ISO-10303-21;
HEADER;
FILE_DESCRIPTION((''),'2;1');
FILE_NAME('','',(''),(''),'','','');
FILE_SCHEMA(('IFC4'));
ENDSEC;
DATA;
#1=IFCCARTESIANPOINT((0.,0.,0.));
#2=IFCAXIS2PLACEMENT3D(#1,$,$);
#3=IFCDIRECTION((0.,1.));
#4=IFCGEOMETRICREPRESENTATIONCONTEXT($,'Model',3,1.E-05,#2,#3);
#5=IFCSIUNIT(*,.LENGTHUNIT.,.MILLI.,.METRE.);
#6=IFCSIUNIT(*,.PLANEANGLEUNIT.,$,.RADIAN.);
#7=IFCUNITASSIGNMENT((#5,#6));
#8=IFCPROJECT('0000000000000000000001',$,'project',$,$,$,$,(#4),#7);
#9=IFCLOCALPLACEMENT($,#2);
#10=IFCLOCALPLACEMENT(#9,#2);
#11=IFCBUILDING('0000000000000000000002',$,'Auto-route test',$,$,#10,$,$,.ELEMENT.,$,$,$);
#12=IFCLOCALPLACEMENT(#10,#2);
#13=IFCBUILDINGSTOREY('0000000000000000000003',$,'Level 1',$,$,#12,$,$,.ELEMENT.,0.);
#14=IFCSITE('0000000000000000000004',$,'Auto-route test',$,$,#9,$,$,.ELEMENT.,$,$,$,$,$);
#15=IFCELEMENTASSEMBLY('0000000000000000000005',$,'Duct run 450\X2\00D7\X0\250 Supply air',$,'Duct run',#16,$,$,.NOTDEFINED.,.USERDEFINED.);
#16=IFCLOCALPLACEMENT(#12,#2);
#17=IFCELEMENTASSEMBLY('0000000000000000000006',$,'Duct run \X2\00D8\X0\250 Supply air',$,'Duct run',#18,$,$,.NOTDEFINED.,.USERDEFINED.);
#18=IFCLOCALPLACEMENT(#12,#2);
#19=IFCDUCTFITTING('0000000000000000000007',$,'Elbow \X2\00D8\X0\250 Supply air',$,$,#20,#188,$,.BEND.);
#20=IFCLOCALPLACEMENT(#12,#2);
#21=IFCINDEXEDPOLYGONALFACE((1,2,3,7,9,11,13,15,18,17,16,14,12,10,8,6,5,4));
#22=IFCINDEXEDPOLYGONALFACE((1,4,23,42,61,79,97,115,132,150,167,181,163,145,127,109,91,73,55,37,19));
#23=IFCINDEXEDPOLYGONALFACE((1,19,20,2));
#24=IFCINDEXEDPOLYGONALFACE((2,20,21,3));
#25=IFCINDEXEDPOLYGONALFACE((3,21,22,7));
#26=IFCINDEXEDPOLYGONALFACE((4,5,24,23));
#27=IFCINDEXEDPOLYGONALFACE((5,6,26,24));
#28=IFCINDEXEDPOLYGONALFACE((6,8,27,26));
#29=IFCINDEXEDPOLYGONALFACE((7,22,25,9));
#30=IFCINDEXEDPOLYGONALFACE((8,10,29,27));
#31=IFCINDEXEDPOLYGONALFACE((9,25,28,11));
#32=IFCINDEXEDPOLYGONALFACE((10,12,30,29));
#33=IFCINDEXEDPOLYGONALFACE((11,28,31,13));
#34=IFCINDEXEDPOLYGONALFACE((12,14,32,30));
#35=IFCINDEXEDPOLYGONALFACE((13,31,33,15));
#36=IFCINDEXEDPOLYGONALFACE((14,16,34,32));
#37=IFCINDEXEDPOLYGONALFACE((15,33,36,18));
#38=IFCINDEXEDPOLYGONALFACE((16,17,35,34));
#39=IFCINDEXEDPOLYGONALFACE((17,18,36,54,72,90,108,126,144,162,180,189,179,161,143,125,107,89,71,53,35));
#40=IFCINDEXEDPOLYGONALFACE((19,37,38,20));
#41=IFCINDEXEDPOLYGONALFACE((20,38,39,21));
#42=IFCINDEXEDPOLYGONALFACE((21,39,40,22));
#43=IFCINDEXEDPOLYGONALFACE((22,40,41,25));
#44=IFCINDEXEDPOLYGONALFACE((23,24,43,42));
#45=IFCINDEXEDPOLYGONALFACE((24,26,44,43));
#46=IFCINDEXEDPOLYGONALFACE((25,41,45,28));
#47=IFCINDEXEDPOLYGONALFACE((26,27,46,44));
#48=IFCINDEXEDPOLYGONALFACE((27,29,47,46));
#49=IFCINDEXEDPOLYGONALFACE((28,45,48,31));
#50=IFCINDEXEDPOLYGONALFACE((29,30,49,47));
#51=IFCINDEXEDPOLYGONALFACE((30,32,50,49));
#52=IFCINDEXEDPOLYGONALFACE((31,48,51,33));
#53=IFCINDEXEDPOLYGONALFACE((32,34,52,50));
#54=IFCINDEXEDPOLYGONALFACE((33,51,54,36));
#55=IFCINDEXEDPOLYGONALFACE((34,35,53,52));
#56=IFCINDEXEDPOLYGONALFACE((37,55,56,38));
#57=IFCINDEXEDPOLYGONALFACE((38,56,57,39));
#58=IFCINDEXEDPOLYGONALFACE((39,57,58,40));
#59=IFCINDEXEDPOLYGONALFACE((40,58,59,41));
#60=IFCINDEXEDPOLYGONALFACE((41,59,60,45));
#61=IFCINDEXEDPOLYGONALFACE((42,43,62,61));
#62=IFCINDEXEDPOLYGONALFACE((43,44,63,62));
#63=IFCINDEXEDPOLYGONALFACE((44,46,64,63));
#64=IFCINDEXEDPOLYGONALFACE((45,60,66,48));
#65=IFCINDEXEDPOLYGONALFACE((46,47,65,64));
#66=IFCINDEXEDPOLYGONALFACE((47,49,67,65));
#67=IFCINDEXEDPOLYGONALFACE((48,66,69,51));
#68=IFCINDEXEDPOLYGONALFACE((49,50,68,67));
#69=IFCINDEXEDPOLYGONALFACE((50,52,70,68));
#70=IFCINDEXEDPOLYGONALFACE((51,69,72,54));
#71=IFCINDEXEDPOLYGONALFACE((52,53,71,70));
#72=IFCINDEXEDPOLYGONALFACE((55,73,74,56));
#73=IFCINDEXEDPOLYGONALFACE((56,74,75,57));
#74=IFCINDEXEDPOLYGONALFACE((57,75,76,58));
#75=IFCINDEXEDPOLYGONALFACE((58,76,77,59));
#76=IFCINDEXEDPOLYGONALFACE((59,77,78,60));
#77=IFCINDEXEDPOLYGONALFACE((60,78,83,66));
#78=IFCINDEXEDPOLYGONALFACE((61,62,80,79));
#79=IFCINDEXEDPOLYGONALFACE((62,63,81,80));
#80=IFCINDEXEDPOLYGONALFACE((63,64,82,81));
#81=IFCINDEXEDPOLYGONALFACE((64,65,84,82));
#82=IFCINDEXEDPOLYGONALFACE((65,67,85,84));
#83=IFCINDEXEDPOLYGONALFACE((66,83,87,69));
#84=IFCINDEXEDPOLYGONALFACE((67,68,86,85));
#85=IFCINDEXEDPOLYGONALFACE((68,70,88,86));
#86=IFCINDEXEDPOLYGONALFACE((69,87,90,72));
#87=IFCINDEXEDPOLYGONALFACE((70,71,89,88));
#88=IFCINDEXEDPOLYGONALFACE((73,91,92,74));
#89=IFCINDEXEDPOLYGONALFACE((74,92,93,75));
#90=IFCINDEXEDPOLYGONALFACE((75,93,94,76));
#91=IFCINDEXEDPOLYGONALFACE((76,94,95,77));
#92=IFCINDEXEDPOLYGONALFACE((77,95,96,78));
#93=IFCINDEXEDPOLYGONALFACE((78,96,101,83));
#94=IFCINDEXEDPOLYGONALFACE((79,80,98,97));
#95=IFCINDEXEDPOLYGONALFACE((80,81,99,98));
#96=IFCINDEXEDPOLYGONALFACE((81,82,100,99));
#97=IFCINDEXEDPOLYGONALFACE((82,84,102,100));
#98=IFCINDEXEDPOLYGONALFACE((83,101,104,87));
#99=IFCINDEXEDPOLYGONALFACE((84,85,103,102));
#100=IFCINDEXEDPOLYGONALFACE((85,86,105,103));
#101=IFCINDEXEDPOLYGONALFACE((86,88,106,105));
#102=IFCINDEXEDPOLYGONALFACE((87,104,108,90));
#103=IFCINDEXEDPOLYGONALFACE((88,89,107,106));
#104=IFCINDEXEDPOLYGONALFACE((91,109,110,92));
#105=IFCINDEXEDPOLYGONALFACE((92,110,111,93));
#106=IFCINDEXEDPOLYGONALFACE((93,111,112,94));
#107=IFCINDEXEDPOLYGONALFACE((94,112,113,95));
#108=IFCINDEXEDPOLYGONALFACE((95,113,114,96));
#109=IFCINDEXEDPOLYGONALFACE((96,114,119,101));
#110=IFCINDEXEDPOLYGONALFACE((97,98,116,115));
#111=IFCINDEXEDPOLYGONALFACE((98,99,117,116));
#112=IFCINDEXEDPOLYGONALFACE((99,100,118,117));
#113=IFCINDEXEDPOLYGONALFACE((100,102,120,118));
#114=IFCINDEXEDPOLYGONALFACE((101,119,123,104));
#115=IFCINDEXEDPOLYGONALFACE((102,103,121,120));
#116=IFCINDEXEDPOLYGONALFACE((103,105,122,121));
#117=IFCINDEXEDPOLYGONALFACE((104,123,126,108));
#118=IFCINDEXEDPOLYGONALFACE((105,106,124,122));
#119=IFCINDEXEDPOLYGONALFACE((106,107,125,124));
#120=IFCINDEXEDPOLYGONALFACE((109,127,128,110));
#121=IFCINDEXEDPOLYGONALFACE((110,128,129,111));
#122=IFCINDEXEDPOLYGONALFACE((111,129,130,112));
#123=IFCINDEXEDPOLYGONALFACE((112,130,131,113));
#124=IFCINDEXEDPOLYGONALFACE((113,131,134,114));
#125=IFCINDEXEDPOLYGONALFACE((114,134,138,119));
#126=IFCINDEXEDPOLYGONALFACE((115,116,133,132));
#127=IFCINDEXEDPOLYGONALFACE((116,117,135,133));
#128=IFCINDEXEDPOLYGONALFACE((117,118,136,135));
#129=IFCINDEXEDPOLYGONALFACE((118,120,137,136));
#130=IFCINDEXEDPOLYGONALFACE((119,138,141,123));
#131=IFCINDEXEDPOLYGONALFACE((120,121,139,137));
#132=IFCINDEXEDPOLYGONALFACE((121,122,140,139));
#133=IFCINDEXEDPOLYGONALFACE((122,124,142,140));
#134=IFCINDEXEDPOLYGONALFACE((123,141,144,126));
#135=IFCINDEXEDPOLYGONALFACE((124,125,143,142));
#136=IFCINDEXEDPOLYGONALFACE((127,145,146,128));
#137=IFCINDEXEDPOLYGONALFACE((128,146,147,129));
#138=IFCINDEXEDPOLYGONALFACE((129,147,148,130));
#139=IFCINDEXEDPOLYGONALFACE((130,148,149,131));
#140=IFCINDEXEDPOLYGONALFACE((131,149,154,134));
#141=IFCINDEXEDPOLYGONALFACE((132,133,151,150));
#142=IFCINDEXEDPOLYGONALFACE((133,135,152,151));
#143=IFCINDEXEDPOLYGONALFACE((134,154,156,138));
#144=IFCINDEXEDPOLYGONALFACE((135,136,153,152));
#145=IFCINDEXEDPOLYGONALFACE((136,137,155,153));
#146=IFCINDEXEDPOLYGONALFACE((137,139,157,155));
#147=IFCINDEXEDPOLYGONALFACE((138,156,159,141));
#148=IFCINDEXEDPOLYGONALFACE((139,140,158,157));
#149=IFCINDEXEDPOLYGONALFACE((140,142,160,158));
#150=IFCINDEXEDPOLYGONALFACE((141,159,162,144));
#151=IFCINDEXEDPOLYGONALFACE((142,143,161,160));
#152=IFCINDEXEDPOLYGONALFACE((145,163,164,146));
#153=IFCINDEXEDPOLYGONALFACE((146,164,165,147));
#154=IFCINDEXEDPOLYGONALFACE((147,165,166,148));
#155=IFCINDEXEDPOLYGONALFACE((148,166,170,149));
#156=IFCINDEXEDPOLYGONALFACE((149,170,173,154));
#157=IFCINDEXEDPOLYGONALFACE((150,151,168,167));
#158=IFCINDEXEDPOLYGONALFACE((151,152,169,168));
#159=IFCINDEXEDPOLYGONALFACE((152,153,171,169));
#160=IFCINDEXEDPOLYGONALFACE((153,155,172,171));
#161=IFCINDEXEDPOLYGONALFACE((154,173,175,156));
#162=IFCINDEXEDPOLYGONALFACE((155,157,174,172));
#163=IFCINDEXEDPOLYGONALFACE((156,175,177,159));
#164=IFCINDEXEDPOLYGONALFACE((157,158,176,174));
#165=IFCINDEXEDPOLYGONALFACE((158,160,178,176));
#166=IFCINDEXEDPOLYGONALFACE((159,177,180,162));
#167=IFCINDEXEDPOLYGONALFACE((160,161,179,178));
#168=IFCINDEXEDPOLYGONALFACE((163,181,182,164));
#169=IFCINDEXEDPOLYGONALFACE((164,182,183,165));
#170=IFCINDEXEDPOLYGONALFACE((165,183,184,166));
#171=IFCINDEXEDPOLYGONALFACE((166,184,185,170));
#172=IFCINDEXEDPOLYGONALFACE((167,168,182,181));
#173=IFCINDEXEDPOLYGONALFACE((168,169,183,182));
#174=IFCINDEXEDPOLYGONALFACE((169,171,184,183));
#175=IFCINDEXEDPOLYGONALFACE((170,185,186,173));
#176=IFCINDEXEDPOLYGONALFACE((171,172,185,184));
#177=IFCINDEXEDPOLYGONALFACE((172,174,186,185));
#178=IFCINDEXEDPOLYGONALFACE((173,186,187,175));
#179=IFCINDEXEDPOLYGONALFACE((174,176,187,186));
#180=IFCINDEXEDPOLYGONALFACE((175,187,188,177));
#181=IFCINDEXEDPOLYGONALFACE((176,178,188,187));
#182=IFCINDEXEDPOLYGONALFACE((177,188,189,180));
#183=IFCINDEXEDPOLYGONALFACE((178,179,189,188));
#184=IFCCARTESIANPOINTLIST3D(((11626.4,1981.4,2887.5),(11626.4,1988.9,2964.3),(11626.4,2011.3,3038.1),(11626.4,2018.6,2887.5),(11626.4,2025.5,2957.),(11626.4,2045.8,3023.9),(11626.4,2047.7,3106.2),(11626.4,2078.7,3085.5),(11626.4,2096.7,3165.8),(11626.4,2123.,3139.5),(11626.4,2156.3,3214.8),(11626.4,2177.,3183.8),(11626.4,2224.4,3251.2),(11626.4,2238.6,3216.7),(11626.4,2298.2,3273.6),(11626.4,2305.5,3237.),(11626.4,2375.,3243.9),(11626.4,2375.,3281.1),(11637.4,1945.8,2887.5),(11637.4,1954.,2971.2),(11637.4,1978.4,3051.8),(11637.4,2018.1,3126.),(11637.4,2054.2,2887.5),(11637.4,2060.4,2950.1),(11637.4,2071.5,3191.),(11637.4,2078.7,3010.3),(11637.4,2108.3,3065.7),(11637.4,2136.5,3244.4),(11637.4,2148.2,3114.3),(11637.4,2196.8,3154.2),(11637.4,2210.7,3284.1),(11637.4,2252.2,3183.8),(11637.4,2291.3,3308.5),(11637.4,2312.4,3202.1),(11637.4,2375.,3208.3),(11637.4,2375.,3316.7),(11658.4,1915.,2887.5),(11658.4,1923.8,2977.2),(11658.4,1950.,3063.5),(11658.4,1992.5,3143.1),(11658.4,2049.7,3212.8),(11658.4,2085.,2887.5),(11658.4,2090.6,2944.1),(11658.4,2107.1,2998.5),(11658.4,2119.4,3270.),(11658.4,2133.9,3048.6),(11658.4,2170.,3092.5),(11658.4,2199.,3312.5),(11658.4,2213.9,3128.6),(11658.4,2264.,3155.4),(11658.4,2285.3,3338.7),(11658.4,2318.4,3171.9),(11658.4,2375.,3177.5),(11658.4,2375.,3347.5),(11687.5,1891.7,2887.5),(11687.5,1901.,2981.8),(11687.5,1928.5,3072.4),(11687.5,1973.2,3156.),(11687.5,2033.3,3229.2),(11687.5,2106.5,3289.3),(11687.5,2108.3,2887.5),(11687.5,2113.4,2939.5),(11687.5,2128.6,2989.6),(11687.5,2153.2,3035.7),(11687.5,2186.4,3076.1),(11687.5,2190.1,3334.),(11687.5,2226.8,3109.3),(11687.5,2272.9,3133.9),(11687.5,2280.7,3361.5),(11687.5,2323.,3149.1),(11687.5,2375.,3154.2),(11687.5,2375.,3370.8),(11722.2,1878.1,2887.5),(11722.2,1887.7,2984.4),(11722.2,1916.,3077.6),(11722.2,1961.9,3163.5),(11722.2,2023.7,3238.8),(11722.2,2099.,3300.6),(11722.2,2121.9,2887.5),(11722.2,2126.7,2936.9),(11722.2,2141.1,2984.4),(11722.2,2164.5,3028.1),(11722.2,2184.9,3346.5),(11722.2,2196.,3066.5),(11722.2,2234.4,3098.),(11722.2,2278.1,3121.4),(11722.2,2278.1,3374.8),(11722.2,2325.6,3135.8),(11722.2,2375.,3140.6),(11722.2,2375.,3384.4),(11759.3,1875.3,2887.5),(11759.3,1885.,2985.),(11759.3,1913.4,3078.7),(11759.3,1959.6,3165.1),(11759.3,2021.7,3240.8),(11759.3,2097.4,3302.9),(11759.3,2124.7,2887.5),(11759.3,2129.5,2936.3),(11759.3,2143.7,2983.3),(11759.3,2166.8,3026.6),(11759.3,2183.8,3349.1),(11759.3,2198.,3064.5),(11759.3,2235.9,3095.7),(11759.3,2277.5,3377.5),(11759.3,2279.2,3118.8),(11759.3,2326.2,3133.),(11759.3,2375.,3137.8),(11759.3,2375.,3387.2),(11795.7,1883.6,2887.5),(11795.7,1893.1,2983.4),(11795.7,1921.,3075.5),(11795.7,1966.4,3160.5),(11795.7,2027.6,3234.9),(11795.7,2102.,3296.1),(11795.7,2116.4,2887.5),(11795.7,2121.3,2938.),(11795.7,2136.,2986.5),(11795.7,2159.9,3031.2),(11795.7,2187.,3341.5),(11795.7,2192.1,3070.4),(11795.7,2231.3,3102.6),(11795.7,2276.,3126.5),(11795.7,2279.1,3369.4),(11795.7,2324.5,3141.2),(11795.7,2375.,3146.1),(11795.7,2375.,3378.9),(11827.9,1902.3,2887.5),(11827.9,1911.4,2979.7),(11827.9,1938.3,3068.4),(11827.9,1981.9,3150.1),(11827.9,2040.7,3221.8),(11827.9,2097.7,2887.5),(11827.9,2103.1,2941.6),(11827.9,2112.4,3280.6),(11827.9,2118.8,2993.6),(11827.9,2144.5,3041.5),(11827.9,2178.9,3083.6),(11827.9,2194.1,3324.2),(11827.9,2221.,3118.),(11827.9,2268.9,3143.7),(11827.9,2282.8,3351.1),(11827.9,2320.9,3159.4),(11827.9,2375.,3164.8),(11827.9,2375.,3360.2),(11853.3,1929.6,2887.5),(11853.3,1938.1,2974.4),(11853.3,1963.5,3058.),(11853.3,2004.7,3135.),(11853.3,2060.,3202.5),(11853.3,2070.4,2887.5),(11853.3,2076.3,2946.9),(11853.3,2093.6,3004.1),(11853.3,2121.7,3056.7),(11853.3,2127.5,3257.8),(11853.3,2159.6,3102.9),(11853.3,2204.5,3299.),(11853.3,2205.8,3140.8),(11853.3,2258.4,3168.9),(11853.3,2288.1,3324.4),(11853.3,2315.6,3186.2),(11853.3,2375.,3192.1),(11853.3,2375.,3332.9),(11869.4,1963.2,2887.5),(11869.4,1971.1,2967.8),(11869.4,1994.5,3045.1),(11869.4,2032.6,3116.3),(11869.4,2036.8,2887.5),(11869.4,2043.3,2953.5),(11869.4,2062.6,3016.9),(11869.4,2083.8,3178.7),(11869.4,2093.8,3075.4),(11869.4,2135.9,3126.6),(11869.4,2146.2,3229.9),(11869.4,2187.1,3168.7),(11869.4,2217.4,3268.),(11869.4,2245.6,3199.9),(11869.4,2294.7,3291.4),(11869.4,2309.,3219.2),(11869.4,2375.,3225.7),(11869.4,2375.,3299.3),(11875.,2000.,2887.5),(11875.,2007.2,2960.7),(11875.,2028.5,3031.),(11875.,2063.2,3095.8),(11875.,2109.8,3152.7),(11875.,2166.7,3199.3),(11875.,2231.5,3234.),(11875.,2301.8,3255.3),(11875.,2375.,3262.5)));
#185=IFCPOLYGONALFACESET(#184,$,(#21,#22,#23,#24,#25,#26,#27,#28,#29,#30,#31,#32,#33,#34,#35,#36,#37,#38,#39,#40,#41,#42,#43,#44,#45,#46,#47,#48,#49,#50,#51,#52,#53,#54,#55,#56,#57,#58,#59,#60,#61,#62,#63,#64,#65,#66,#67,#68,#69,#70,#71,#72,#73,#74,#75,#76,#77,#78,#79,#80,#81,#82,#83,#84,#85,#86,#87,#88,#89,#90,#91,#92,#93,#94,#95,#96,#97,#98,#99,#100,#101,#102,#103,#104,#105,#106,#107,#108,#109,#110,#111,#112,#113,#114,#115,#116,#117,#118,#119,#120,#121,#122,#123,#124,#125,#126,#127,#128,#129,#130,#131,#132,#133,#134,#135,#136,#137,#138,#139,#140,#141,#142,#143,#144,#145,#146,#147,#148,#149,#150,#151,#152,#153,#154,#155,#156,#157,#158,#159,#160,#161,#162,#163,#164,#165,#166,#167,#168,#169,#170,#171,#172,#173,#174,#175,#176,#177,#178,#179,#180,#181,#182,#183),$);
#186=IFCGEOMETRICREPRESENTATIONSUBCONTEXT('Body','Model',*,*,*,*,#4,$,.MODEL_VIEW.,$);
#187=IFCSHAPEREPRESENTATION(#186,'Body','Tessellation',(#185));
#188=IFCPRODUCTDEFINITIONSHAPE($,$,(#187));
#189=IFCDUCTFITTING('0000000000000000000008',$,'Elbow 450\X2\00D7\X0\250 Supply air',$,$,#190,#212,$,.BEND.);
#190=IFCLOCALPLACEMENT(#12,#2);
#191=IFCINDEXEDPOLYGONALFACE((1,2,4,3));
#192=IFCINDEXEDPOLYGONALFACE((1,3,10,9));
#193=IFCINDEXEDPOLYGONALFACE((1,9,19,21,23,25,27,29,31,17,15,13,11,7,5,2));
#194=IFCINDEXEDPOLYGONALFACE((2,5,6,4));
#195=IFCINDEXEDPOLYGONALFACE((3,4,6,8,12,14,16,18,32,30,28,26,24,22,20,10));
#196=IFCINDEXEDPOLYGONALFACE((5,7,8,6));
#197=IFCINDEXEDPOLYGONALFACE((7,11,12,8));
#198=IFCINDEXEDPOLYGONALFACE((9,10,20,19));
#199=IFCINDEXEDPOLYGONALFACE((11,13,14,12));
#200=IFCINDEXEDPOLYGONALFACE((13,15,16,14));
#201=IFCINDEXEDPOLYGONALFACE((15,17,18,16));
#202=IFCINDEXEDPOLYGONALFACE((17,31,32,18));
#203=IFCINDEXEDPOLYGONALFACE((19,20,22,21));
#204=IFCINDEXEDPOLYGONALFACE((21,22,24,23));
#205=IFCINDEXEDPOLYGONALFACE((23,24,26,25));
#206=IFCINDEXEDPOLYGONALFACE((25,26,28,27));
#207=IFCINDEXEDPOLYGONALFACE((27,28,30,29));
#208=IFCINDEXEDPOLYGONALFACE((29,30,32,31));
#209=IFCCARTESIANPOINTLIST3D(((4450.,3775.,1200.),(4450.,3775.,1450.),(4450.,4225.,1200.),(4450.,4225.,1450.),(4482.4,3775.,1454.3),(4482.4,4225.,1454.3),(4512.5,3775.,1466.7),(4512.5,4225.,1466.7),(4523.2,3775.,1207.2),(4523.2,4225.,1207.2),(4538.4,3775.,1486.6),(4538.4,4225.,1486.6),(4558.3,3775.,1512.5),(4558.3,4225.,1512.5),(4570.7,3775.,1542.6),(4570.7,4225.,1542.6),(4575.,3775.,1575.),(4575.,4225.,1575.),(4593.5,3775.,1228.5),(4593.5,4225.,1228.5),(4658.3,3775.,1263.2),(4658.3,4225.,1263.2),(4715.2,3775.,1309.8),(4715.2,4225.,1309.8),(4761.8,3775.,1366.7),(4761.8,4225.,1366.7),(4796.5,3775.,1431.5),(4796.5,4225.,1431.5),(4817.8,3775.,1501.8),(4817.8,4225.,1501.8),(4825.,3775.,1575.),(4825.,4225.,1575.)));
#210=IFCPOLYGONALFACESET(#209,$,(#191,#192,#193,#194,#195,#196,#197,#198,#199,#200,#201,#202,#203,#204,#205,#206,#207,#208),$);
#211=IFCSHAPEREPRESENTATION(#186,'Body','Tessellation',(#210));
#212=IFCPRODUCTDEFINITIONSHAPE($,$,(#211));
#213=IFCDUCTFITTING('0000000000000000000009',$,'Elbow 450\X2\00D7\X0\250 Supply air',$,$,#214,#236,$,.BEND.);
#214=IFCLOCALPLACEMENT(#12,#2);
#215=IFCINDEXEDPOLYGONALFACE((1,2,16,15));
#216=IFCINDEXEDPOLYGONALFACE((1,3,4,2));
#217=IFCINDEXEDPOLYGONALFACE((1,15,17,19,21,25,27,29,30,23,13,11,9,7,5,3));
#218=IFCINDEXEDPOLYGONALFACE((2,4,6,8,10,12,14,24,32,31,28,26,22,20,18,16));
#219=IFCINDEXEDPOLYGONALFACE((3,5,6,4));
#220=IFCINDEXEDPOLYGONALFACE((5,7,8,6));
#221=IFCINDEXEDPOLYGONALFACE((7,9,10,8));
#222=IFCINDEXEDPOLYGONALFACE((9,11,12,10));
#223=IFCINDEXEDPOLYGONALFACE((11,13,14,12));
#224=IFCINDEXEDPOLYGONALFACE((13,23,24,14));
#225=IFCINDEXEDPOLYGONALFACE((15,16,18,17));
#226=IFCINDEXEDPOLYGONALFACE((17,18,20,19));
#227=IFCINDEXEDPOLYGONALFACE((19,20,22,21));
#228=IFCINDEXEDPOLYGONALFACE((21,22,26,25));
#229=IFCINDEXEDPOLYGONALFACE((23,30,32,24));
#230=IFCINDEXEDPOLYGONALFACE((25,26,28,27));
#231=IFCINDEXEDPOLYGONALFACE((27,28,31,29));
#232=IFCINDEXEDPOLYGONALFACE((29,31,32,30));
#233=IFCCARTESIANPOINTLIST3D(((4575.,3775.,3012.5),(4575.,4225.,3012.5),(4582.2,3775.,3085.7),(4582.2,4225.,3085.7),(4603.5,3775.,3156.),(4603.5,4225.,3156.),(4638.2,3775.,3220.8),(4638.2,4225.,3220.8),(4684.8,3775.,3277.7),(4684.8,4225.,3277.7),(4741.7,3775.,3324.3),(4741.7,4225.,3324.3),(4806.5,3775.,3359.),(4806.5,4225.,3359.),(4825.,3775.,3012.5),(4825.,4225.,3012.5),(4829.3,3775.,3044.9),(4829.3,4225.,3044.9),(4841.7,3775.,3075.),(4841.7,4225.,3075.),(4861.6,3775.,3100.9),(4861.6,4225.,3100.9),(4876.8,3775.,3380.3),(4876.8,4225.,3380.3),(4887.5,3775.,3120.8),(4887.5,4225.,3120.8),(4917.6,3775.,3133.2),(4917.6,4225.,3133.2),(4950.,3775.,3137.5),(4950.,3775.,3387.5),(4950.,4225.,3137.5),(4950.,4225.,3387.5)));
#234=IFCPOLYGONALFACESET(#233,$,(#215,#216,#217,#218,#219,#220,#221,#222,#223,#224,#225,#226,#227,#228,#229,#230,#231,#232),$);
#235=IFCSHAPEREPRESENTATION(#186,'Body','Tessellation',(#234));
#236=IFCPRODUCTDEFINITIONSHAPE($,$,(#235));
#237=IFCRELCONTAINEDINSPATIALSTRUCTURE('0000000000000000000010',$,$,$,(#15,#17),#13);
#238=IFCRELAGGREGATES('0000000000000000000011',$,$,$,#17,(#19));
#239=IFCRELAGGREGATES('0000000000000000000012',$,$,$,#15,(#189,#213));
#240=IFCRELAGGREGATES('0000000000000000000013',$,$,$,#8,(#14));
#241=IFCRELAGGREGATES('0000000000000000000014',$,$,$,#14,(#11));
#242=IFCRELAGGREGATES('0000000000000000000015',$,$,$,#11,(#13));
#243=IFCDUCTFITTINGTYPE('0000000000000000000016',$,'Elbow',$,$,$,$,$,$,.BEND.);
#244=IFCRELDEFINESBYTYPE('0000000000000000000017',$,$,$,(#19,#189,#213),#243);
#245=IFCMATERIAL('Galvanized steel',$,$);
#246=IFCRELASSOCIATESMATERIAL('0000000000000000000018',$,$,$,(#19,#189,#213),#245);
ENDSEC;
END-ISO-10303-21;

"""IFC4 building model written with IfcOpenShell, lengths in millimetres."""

from ifc_helpers import new_model, entity, si_unit, direction, origin, origin_with_axes, place, context, subcontext, project, spatial, material, type_object, element, aggregate, save


model = new_model("IFC4")

# Units and contexts
model_context = context("Model", 3, precision=1e-05, world=origin(), true_north=direction((0.0, 1.0)))
body_context = subcontext(model_context, "Body", "Model", "MODEL_VIEW")
ifc_project = project(units=[si_unit("LENGTHUNIT", "METRE", prefix="MILLI"), si_unit("PLANEANGLEUNIT", "RADIAN")], contexts=[model_context])

# Site, building, storey
site_placement = place(None, origin())
site = spatial("IfcSite", under=ifc_project, at=site_placement, Name="Auto-route test", CompositionType="ELEMENT")
building_placement = place(site_placement, origin())
building = spatial("IfcBuilding", under=site, at=building_placement, Name="Auto-route test", CompositionType="ELEMENT")
storey_placement = place(building_placement, origin())
storey = spatial("IfcBuildingStorey", under=building, at=storey_placement, Name="Level 1", CompositionType="ELEMENT", Elevation=0.0)

# Element assembly
assembly_1_placement = place(storey_placement, origin_with_axes())
assembly_1 = element("IfcElementAssembly", 1, at=assembly_1_placement, inside=storey, Name="Duct run 450×250 Supply air", ObjectType="Duct run", AssemblyPlace="NOTDEFINED", PredefinedType="USERDEFINED")
ifc_material_1 = material(Name="Galvanized steel")

# Element assembly, duct fitting
assembly_2_placement = place(storey_placement, origin_with_axes())
assembly_2 = element("IfcElementAssembly", 2, at=assembly_2_placement, inside=storey, Name="Duct run Ø250 Supply air", ObjectType="Duct run", AssemblyPlace="NOTDEFINED", PredefinedType="USERDEFINED")
duct_fitting_type_1 = type_object("IfcDuctFittingType", Name="Elbow", PredefinedType="BEND")
duct_fitting_1_placement = place(storey_placement, origin_with_axes())
duct_fitting_1 = element("IfcDuctFitting", 3, at=duct_fitting_1_placement, type_object=duct_fitting_type_1, material=ifc_material_1, Name="Elbow Ø250 Supply air", PredefinedType="BEND", context=body_context, shape_type="SweptSolid", body=[
    entity("IfcRevolvedAreaSolid", entity("IfcCircleProfileDef", "AREA", None, entity("IfcAxis2Placement2D", entity("IfcCartesianPoint", [0.0, 0.0])), 125.0), entity("IfcAxis2Placement3D", entity("IfcCartesianPoint", [11750.0, 2375.0, 3262.5]), entity("IfcDirection", [0.0, -1.0, 0.0]), entity("IfcDirection", [1.0, 0.0, 0.0])), entity("IfcAxis1Placement", entity("IfcCartesianPoint", [0.0, -375.0, 0.0]), entity("IfcDirection", [1.0, 0.0, 0.0])), 1.570796),
])

# Duct fittings
duct_fitting_2_placement = place(storey_placement, origin_with_axes())
duct_fitting_2 = element("IfcDuctFitting", 4, at=duct_fitting_2_placement, type_object=duct_fitting_type_1, material=ifc_material_1, Name="Elbow 450×250 Supply air", PredefinedType="BEND", context=body_context, shape_type="SweptSolid", body=[
    entity("IfcRevolvedAreaSolid", entity("IfcRectangleProfileDef", "AREA", None, entity("IfcAxis2Placement2D", entity("IfcCartesianPoint", [0.0, 0.0])), 450.0, 250.0), entity("IfcAxis2Placement3D", entity("IfcCartesianPoint", [4450.0, 4000.0, 1325.0]), entity("IfcDirection", [1.0, 0.0, 0.0]), entity("IfcDirection", [0.0, 1.0, 0.0])), entity("IfcAxis1Placement", entity("IfcCartesianPoint", [0.0, 250.0, 0.0]), entity("IfcDirection", [-1.0, 0.0, 0.0])), 1.570796),
])
duct_fitting_3_placement = place(storey_placement, origin_with_axes())
duct_fitting_3 = element("IfcDuctFitting", 5, at=duct_fitting_3_placement, type_object=duct_fitting_type_1, material=ifc_material_1, Name="Elbow 450×250 Supply air", PredefinedType="BEND", context=body_context, shape_type="SweptSolid", body=[
    entity("IfcRevolvedAreaSolid", entity("IfcRectangleProfileDef", "AREA", None, entity("IfcAxis2Placement2D", entity("IfcCartesianPoint", [0.0, 0.0])), 450.0, 250.0), entity("IfcAxis2Placement3D", entity("IfcCartesianPoint", [4700.0, 4000.0, 3012.5]), entity("IfcDirection", [0.0, 0.0, 1.0]), entity("IfcDirection", [0.0, 1.0, 0.0])), entity("IfcAxis1Placement", entity("IfcCartesianPoint", [0.0, -250.0, 0.0]), entity("IfcDirection", [1.0, 0.0, 0.0])), 1.570796),
])

aggregate(assembly_2, [duct_fitting_1])

aggregate(assembly_1, [duct_fitting_2, duct_fitting_3])

save(model, "model.ifc")
